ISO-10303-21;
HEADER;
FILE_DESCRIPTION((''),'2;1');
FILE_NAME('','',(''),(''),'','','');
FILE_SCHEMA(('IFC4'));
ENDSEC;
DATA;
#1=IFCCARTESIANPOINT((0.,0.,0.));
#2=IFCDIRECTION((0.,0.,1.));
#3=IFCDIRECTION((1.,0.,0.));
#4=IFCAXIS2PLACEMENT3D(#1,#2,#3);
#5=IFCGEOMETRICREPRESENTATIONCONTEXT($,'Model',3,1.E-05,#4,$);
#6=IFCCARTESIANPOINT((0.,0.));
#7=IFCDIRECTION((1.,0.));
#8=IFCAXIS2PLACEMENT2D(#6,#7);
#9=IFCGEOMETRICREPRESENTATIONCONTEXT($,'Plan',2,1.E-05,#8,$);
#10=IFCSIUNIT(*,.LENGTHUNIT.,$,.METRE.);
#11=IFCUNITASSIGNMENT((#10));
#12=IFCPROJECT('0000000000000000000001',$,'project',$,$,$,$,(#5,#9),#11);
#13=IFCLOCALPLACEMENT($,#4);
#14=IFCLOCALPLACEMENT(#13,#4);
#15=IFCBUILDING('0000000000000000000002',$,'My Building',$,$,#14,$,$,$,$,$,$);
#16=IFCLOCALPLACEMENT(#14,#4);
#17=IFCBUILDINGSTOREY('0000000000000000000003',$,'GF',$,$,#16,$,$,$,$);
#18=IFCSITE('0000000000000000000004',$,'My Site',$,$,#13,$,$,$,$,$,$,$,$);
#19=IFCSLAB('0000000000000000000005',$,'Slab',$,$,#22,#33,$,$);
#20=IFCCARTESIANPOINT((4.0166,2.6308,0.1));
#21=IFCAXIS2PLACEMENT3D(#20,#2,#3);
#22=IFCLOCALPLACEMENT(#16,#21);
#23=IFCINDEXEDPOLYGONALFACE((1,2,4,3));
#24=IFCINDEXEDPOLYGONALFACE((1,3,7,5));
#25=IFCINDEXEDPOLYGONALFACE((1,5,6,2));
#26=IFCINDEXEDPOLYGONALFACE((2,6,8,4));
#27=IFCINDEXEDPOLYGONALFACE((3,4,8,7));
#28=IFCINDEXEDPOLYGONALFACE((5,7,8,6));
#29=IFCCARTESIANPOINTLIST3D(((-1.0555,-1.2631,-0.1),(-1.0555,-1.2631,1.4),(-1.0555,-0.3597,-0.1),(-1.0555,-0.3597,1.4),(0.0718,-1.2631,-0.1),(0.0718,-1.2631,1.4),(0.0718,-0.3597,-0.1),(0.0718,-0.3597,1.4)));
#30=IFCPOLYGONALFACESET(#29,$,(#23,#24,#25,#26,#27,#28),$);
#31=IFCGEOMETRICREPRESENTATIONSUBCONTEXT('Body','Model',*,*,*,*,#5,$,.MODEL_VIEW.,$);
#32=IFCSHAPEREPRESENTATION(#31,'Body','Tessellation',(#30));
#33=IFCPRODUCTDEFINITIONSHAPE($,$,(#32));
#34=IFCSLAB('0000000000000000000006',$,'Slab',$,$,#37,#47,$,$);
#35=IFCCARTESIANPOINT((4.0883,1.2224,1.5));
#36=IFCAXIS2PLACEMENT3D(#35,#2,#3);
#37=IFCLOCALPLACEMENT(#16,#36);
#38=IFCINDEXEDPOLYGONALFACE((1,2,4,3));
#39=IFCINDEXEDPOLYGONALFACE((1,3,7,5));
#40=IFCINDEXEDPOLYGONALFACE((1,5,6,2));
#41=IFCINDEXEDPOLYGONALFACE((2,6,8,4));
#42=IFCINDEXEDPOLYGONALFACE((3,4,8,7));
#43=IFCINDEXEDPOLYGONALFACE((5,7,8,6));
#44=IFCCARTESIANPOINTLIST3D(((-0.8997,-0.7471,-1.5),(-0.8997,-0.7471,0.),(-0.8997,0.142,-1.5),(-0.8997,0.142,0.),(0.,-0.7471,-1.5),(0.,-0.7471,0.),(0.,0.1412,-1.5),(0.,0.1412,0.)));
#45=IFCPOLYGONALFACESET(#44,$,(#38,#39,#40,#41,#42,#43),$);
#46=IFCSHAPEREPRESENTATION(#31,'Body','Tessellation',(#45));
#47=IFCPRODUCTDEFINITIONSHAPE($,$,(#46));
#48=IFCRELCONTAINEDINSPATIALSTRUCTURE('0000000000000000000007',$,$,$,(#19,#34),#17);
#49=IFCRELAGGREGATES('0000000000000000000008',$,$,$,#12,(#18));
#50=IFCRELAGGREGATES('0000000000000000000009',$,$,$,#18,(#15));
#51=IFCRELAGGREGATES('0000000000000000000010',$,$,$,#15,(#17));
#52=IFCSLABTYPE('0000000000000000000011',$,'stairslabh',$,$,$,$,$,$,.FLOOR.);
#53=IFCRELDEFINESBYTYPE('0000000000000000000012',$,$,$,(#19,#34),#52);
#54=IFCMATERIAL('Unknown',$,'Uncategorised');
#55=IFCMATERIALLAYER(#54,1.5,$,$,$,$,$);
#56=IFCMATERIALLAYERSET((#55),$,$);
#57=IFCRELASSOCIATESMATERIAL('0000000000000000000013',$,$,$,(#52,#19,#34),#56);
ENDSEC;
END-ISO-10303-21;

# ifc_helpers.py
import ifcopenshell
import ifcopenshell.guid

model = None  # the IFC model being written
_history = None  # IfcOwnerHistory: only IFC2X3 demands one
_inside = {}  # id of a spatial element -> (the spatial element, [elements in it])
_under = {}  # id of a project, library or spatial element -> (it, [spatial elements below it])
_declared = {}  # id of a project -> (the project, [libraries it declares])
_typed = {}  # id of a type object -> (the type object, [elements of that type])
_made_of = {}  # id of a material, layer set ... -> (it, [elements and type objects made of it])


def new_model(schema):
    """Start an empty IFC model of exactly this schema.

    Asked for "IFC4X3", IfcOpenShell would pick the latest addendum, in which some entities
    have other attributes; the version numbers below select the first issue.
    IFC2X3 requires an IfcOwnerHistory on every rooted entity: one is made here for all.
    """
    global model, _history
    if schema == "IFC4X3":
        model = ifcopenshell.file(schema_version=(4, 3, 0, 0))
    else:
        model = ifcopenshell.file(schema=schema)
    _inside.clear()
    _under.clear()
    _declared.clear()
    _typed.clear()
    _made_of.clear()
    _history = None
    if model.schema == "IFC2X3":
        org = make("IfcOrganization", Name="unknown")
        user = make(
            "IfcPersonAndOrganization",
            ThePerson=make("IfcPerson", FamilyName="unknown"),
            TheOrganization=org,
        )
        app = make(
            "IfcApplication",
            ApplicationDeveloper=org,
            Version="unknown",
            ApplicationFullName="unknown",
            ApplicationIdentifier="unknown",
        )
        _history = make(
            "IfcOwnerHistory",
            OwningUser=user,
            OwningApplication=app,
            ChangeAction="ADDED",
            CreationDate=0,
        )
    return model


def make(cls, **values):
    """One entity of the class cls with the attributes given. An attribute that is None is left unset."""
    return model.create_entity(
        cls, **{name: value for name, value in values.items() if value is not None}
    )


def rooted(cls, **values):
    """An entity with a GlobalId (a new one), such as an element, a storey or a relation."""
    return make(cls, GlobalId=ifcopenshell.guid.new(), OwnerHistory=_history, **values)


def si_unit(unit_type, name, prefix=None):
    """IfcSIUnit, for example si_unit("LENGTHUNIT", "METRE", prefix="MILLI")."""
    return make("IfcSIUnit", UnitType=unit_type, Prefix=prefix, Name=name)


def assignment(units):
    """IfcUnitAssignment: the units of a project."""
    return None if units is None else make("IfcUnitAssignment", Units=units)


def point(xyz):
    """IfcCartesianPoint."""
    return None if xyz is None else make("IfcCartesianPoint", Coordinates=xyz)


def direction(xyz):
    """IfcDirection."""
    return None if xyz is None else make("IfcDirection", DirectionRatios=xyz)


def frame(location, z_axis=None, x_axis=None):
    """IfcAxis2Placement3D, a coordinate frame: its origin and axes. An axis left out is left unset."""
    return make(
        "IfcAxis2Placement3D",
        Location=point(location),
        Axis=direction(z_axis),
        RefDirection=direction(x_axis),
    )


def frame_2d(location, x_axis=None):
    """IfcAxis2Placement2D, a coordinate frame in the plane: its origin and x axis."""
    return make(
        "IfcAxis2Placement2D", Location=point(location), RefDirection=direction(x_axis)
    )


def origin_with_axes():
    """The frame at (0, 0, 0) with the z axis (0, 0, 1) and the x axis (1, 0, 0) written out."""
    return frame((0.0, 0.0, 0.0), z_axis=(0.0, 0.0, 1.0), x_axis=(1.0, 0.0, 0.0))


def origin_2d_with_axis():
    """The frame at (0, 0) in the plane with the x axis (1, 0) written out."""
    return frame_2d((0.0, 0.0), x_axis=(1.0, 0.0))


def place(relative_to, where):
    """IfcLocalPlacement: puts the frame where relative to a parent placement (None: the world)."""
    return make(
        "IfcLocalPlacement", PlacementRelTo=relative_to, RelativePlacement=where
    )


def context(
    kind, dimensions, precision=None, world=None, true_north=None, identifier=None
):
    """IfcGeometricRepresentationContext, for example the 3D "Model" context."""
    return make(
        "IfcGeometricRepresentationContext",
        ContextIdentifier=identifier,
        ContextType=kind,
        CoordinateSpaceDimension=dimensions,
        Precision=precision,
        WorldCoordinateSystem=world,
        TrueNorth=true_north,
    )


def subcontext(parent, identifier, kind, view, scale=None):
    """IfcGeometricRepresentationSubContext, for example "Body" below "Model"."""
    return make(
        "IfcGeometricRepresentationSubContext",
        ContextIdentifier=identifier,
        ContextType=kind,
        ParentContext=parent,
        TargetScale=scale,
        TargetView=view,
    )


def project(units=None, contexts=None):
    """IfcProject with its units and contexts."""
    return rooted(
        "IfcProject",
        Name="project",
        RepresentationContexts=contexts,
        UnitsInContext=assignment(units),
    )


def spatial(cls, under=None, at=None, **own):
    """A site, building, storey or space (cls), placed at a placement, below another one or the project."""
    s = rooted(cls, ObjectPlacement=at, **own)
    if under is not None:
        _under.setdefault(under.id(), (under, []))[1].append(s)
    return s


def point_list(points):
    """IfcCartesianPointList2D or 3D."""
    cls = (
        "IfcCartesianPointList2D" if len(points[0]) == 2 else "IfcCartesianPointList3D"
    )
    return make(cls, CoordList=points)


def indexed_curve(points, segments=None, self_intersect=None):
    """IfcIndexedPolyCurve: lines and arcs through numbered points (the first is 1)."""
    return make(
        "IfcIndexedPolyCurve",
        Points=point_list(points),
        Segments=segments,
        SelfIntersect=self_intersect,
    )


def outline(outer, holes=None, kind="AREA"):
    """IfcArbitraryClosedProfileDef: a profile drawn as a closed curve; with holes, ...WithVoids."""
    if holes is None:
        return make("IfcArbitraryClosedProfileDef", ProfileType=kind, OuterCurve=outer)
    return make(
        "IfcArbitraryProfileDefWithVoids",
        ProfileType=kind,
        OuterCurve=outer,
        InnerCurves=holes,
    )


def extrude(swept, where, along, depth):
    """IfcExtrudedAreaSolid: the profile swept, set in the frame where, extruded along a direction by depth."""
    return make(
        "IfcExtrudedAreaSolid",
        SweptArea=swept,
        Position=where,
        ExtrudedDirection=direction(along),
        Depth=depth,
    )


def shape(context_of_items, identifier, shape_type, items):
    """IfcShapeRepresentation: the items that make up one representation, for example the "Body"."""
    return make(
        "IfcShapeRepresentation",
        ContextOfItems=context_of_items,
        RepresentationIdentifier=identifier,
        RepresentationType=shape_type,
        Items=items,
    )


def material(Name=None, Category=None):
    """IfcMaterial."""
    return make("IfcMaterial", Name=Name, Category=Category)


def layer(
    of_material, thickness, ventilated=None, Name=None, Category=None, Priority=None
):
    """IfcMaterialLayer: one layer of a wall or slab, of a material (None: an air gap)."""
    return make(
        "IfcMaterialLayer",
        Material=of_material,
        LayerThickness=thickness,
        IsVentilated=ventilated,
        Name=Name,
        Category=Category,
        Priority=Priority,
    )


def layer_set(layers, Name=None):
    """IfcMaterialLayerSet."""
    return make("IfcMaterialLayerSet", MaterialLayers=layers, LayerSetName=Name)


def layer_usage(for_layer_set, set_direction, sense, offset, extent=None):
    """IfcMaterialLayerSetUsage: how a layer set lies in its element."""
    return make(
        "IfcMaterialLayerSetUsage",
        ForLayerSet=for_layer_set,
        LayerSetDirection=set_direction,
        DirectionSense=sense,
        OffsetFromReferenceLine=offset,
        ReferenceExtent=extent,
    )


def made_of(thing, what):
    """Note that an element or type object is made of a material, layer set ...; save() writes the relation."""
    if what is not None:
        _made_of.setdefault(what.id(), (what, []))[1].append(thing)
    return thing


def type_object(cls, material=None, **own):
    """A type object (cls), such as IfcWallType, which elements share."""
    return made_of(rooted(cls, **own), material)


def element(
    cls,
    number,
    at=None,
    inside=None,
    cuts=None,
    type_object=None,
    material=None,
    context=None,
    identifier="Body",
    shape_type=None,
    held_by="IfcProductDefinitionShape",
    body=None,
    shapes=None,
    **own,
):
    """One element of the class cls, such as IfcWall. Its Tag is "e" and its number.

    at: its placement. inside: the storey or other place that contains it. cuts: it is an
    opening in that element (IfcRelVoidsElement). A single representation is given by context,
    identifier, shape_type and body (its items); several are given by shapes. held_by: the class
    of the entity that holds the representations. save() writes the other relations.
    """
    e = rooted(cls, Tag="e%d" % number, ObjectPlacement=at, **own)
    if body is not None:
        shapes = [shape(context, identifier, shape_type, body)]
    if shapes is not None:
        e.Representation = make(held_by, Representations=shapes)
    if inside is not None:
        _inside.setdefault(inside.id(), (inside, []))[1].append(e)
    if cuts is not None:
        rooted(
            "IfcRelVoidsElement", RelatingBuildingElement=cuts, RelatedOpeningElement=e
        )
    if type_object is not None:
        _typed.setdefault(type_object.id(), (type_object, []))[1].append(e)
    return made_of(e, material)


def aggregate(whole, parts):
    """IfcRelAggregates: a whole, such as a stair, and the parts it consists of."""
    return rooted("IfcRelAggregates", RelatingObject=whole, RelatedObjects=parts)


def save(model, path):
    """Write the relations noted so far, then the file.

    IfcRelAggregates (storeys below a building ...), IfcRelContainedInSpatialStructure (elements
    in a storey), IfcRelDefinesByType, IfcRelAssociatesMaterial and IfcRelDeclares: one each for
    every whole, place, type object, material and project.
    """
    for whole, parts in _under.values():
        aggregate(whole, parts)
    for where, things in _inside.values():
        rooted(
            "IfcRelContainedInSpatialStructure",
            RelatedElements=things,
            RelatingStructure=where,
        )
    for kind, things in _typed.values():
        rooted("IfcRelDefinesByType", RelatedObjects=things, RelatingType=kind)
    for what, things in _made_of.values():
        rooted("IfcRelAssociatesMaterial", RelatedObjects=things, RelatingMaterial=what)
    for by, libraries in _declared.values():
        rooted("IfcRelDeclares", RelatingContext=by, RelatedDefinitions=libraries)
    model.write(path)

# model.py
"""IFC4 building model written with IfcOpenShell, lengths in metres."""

from ifc_helpers import new_model, si_unit, frame, origin_with_axes, origin_2d_with_axis, place, context, subcontext, project, spatial, indexed_curve, outline, extrude, material, layer, layer_set, layer_usage, type_object, element, save


model = new_model("IFC4")

# Units and contexts
model_context = context("Model", 3, precision=1e-05, world=origin_with_axes())
plan_context = context("Plan", 2, precision=1e-05, world=origin_2d_with_axis())
body_context_1 = subcontext(model_context, "Body", "Model", "MODEL_VIEW")
ifc_project = project(units=[si_unit("LENGTHUNIT", "METRE")], contexts=[model_context, plan_context])

# Site, building, storey
site_placement = place(None, origin_with_axes())
site = spatial("IfcSite", under=ifc_project, at=site_placement, Name="My Site")
building_placement = place(site_placement, origin_with_axes())
building = spatial("IfcBuilding", under=site, at=building_placement, Name="My Building")
storey_placement = place(building_placement, origin_with_axes())
storey = spatial("IfcBuildingStorey", under=building, at=storey_placement, Name="GF")

# Shared definitions
ifc_material = material(Name="Unknown", Category="Uncategorised")

# Slabs
ifc_layer_1 = layer(ifc_material, 1.5)
ifc_layer_set_1 = layer_set([ifc_layer_1])
ifc_layer_usage_1 = layer_usage(ifc_layer_set_1, "AXIS3", "POSITIVE", -0.1)
slab_type_1 = type_object("IfcSlabType", Name="stairslabh", PredefinedType="FLOOR", material=ifc_layer_set_1)
slab_1_placement = place(storey_placement, frame((4.0166, 2.6308, 0.1), z_axis=(0.0, 0.0, 1.0), x_axis=(1.0, 0.0, 0.0)))
element("IfcSlab", 1, at=slab_1_placement, inside=storey, type_object=slab_type_1, material=ifc_layer_usage_1, Name="Slab", context=body_context_1, shape_type="SweptSolid", body=[
    extrude(outline(indexed_curve([(0.0718, -1.2631), (0.0718, -0.3597), (-1.0555, -0.3597), (-1.0555, -1.2631), (0.0718, -1.2631)])), frame((0.0, 0.0, -0.1), z_axis=(0.0, 0.0, 1.0), x_axis=(1.0, 0.0, 0.0)), (0.0, 0.0, 1.0), 1.5),
])
ifc_layer_usage_2 = layer_usage(ifc_layer_set_1, "AXIS3", "POSITIVE", -1.5)
slab_2_placement = place(storey_placement, frame((4.0883, 1.2224, 1.5), z_axis=(0.0, 0.0, 1.0), x_axis=(1.0, 0.0, 0.0)))
element("IfcSlab", 2, at=slab_2_placement, inside=storey, type_object=slab_type_1, material=ifc_layer_usage_2, Name="Slab", context=body_context_1, shape_type="SweptSolid", body=[
    extrude(outline(indexed_curve([(-0.8997, 0.142), (-0.8997, -0.7471), (0.0, -0.7471), (0.0, 0.1412), (-0.8997, 0.142)])), frame((0.0, 0.0, -1.5), z_axis=(0.0, 0.0, 1.0), x_axis=(1.0, 0.0, 0.0)), (0.0, 0.0, 1.0), 1.5),
])

save(model, "model.ifc")
